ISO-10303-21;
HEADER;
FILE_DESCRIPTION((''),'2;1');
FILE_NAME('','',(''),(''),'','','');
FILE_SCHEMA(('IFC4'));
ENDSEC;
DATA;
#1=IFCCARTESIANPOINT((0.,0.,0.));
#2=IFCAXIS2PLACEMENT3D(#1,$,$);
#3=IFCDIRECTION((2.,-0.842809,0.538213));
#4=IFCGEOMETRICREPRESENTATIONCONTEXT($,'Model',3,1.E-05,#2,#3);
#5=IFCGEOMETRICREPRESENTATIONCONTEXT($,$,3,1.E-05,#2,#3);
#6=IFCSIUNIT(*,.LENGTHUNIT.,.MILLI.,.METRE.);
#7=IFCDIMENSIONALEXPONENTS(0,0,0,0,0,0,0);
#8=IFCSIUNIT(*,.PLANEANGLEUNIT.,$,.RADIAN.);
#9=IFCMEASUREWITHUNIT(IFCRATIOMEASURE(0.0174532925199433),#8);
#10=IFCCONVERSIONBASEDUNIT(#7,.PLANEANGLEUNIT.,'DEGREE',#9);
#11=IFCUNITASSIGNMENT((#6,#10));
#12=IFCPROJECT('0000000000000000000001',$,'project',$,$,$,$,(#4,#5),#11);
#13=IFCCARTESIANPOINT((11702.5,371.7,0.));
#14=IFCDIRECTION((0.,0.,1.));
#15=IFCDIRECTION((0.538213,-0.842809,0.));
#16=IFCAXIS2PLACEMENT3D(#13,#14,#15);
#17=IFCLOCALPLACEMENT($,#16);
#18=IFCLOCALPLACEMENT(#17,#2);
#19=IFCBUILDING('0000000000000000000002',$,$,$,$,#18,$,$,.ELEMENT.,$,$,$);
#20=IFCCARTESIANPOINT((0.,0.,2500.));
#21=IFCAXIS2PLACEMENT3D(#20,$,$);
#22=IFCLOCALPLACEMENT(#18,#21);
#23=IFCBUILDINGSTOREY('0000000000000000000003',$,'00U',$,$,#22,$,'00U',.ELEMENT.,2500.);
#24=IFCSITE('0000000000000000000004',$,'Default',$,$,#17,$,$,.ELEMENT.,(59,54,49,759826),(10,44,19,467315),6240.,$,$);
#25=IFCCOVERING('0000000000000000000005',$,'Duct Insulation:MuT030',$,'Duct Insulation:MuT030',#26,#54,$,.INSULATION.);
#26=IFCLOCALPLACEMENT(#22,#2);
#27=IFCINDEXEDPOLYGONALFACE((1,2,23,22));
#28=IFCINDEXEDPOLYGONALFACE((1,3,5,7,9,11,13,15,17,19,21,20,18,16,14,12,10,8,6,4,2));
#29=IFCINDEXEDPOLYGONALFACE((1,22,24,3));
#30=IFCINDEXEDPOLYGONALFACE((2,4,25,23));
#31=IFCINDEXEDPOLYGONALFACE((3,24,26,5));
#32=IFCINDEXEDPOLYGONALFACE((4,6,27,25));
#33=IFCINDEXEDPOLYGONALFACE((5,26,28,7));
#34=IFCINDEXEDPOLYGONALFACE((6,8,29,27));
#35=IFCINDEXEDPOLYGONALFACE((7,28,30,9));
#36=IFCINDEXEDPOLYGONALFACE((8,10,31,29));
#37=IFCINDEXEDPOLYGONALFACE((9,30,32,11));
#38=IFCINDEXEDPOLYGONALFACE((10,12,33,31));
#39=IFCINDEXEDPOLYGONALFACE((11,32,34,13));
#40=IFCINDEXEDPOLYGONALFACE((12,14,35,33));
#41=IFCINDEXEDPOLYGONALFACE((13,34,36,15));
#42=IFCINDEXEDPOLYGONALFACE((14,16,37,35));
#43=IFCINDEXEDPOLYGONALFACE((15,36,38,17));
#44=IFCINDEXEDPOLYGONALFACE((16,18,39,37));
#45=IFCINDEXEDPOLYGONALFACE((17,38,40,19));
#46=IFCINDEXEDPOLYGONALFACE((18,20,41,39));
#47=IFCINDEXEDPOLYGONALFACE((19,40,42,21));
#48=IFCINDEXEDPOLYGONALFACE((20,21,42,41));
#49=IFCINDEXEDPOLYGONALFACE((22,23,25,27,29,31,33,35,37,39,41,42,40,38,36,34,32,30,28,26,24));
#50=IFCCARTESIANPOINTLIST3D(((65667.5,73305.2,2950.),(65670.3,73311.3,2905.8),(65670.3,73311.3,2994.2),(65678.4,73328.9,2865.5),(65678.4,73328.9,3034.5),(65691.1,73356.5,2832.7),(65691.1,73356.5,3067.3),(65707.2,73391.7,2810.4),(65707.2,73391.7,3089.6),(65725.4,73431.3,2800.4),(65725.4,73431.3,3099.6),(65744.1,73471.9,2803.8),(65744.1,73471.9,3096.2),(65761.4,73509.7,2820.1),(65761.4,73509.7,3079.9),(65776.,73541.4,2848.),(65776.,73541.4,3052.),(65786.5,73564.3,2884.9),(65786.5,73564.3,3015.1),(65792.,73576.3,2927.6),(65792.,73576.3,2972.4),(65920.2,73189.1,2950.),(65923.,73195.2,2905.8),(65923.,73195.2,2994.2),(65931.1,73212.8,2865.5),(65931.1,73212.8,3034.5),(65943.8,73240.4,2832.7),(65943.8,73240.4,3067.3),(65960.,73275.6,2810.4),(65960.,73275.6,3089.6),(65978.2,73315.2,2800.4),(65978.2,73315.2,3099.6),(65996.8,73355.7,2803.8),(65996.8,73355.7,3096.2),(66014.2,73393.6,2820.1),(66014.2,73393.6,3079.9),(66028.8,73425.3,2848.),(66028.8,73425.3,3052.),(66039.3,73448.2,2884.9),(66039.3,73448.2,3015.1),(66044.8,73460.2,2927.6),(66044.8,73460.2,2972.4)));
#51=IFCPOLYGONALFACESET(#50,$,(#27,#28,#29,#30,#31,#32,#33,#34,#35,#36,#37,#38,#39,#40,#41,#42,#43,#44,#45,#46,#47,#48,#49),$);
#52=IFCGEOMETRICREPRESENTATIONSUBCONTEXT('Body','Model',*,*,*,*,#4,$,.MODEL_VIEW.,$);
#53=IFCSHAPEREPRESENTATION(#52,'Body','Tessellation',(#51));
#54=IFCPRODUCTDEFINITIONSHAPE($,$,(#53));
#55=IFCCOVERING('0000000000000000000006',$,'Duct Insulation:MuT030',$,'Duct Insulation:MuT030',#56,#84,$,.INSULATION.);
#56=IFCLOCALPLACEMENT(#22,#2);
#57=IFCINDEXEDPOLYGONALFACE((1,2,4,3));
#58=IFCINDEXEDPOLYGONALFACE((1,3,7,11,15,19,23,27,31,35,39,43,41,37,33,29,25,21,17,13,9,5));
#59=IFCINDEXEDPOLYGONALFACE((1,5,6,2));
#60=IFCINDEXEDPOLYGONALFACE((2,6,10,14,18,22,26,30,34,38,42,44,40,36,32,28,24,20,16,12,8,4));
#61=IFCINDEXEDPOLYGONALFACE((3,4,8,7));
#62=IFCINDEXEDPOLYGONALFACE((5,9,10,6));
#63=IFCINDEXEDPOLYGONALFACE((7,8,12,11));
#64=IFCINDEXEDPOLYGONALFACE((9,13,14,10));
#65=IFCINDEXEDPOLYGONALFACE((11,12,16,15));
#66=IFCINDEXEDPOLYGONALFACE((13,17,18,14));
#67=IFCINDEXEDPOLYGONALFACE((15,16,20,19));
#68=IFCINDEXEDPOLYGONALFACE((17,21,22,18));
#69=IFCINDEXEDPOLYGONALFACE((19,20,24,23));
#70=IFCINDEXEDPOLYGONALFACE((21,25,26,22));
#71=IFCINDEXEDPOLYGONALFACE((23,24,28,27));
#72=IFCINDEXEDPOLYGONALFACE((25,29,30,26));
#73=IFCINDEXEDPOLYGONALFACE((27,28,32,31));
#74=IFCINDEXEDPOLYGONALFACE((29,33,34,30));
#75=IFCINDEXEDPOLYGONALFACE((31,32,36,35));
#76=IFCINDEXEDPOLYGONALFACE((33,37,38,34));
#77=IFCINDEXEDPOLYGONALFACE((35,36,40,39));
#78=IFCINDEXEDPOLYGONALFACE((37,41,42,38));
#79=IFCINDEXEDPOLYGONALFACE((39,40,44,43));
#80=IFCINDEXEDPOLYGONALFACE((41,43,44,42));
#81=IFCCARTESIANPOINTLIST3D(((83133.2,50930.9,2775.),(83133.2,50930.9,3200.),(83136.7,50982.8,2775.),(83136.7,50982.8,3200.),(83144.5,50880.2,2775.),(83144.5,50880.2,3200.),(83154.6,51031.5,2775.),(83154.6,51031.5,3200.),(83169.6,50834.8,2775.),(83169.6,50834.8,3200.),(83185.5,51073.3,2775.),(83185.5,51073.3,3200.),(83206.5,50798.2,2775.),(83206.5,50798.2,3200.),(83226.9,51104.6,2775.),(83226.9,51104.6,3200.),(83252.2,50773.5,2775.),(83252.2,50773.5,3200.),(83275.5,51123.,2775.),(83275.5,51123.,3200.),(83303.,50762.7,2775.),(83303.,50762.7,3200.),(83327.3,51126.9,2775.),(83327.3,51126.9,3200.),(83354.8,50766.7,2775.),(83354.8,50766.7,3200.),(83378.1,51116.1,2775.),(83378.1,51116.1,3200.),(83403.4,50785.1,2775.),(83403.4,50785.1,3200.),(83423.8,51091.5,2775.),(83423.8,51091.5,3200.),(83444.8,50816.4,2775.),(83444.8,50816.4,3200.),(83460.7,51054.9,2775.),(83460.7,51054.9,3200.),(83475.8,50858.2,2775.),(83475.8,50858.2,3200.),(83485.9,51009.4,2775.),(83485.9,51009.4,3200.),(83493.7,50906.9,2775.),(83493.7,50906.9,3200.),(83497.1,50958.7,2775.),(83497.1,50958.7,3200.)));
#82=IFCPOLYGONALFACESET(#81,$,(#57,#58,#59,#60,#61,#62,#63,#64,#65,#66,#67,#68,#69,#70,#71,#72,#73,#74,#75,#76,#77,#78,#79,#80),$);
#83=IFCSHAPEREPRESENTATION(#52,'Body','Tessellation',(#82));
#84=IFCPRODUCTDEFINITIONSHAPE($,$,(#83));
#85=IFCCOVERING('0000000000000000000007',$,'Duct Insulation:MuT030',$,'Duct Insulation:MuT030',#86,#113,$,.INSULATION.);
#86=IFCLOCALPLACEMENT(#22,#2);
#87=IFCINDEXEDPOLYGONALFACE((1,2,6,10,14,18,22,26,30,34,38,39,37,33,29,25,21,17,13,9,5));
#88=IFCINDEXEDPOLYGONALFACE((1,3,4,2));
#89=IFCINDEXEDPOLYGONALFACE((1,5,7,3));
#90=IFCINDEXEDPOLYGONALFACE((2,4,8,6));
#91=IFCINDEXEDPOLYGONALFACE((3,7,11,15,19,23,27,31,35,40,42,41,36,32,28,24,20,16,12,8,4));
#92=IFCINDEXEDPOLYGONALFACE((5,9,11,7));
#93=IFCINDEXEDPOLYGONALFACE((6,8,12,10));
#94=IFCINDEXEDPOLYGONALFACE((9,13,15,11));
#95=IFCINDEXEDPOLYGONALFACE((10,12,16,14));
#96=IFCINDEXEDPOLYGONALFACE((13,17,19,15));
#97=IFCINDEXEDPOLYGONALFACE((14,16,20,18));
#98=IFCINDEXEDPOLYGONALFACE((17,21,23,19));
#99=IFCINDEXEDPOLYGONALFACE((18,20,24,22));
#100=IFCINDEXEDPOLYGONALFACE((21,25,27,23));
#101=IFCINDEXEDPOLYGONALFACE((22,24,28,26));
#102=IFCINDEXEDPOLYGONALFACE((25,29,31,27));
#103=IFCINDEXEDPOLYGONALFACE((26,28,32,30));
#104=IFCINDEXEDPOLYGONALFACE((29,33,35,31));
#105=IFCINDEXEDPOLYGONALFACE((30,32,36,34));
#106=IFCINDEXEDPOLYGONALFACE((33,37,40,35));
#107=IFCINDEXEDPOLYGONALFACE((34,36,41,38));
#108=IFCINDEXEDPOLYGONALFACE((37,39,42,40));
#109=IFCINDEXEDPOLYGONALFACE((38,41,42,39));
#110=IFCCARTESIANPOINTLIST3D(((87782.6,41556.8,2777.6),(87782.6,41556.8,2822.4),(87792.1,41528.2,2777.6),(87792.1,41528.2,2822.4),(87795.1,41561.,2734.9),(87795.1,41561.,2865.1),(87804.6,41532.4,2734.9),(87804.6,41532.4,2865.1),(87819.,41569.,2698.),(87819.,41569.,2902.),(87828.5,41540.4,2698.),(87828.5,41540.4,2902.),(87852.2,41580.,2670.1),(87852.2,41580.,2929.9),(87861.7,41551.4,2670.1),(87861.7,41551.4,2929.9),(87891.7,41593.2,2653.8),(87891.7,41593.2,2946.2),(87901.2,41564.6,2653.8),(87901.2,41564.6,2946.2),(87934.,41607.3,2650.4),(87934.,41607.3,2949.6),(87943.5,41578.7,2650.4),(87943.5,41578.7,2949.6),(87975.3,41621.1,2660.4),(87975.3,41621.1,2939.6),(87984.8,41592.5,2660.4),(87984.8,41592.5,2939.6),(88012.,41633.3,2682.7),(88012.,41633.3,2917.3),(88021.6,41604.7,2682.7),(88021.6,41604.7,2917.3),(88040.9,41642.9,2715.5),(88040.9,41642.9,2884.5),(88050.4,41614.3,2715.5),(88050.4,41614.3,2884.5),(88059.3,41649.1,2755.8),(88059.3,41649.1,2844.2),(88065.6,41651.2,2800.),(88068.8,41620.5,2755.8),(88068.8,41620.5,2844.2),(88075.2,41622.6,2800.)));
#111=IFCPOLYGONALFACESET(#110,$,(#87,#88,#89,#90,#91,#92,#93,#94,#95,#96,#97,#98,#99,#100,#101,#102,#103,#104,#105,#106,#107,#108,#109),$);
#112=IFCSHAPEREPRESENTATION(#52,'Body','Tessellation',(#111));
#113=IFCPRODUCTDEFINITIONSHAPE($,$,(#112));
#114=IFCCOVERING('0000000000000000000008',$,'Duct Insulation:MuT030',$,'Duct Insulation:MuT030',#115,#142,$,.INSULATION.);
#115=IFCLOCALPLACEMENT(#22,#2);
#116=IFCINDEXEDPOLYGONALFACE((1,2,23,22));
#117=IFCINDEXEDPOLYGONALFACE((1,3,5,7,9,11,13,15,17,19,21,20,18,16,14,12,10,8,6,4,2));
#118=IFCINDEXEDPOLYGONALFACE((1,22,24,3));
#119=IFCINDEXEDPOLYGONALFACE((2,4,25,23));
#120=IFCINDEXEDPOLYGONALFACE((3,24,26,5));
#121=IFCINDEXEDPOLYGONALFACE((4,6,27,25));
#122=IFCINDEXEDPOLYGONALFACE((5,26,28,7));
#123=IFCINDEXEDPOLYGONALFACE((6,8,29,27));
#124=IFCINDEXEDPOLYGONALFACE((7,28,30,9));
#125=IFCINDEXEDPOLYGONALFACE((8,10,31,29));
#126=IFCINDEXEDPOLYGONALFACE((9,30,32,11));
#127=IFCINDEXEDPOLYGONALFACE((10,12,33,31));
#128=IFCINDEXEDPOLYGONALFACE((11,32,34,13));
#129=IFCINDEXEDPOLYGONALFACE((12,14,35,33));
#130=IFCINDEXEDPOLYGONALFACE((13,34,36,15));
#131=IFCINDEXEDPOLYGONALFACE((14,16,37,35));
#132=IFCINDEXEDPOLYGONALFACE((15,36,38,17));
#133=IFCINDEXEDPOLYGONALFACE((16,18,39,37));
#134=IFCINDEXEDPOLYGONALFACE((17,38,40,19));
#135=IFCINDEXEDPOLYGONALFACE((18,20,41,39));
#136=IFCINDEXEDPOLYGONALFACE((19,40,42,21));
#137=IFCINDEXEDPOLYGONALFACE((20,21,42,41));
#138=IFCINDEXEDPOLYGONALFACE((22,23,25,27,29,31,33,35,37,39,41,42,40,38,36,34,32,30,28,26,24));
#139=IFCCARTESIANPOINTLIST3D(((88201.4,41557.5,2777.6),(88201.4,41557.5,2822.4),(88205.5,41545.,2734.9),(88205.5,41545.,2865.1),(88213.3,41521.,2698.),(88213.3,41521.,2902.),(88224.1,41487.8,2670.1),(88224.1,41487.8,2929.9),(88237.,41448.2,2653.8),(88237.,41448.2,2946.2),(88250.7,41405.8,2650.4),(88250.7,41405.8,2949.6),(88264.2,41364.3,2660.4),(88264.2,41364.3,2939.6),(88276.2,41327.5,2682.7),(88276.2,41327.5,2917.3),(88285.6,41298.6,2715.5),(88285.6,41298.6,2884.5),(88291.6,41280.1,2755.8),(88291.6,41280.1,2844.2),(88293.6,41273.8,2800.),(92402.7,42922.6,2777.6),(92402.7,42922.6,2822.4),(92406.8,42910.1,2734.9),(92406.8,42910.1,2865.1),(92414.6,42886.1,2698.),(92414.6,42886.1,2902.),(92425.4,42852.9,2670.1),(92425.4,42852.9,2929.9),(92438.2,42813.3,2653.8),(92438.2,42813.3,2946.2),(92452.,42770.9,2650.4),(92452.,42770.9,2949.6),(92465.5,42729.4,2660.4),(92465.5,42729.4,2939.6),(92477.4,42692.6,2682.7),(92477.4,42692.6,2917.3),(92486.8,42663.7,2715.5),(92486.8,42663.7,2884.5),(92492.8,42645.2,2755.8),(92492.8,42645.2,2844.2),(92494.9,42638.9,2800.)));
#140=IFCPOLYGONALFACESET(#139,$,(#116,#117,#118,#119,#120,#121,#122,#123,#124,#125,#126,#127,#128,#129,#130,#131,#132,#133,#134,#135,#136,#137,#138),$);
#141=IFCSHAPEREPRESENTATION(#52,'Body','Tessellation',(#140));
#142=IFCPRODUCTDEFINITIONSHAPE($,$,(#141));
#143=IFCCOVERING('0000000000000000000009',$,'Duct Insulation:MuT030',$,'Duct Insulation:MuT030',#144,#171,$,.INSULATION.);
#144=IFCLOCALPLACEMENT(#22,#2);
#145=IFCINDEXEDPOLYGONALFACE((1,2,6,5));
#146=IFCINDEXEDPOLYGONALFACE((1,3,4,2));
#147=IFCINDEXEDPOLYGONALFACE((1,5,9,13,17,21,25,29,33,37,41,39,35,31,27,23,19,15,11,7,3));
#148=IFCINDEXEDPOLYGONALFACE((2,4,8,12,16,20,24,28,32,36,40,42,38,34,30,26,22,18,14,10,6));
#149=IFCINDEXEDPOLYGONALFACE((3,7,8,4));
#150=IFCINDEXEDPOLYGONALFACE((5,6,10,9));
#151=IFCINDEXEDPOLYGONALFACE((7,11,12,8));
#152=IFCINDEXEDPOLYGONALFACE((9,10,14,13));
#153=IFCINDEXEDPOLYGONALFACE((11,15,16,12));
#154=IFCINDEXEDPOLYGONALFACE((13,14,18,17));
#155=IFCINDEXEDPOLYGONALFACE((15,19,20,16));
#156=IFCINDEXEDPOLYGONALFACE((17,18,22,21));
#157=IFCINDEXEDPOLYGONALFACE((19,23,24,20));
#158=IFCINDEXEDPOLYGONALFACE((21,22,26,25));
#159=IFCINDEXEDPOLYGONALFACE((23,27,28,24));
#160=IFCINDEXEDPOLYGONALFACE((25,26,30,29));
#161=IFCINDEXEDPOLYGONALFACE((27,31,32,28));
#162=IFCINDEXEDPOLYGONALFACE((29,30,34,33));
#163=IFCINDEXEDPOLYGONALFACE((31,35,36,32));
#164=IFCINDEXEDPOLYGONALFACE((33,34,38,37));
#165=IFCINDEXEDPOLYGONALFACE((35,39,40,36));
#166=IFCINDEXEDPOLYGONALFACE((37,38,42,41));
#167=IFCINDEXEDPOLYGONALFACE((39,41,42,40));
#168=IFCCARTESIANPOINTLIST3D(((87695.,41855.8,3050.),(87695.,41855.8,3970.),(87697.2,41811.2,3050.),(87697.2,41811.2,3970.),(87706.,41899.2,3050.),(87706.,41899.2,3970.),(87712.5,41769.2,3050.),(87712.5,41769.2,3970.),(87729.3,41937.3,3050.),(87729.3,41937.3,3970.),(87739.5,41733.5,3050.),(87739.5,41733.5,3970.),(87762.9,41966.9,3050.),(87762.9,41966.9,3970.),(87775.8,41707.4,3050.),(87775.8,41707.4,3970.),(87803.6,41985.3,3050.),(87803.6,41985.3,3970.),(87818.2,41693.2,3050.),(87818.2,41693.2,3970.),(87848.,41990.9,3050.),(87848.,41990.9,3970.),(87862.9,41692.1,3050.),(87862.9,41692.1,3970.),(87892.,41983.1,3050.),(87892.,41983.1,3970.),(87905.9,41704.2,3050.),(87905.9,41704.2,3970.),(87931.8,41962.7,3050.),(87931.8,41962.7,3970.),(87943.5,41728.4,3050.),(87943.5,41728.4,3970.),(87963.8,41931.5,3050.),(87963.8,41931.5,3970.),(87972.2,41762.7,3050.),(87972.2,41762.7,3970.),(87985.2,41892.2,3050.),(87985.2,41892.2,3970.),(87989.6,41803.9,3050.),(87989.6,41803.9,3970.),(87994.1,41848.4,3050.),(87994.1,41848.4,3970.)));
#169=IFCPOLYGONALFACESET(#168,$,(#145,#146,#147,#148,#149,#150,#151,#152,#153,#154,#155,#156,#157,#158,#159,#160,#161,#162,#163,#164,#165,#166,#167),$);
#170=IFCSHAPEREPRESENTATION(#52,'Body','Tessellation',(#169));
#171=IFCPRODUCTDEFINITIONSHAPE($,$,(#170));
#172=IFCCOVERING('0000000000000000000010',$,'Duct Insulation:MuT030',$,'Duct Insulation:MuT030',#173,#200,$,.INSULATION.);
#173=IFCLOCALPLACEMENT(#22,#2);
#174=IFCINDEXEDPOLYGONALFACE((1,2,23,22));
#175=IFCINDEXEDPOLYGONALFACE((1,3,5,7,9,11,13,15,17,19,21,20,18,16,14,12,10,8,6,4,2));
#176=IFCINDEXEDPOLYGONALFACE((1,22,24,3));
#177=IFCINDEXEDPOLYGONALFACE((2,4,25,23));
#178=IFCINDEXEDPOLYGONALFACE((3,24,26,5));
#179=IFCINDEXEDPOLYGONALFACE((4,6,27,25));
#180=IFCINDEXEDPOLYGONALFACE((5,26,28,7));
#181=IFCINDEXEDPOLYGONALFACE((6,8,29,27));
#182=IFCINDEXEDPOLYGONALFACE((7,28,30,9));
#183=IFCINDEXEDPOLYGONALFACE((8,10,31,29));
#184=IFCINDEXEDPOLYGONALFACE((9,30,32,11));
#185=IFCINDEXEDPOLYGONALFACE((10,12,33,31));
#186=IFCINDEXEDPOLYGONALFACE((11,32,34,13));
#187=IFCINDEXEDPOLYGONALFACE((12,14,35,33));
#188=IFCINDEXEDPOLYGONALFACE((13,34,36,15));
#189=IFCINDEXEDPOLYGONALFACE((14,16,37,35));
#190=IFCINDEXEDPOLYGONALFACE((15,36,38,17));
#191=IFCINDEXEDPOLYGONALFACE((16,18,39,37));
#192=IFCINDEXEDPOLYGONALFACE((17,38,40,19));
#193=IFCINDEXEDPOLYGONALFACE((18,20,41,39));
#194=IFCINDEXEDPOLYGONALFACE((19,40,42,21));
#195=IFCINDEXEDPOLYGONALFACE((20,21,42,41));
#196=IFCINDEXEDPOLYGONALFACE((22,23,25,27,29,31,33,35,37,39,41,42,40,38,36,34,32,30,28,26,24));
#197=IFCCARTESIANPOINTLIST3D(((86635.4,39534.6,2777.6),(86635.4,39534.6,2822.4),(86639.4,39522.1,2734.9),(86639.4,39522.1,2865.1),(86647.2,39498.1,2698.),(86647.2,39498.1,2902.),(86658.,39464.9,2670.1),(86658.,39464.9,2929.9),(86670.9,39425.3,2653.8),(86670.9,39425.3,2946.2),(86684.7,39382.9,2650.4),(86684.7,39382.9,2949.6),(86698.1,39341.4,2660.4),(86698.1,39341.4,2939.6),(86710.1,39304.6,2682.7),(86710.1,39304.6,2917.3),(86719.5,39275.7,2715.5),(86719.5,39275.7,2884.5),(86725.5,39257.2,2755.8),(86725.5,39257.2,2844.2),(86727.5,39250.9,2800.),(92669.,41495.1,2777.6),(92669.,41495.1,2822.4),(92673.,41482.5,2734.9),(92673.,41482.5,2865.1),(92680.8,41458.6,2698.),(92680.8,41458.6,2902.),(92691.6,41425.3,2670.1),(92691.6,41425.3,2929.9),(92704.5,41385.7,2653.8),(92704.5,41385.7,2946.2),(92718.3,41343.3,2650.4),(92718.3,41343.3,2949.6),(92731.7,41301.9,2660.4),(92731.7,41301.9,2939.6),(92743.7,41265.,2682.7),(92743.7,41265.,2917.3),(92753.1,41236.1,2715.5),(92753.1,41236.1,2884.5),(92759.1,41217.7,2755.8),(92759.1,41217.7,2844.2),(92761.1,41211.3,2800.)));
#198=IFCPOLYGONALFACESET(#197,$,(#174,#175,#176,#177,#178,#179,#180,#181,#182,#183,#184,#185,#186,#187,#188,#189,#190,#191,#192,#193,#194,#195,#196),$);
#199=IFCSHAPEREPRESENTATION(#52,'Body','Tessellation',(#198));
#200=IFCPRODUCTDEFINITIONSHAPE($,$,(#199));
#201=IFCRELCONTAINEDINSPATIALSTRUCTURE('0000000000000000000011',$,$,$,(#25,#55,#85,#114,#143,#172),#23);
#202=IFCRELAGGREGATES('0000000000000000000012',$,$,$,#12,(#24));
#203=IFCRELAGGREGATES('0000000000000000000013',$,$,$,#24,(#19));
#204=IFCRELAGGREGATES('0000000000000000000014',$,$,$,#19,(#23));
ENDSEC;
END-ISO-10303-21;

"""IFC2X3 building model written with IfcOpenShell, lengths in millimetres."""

from ifc_helpers import new_model, entity, si_unit, converted_unit, direction, frame, frame_2d, origin, origin_2d_with_axis, place, context, subcontext, project, spatial, circle, extrude, element, save


model = new_model("IFC2X3")

# Units and contexts
model_context = context("Model", 3, precision=1e-05, world=origin(), true_north=direction((2.0, -0.842809, 0.538213)))
context_of_model = context(None, 3, precision=1e-05, world=origin(), true_north=direction((2.0, -0.842809, 0.538213)))
body_context = subcontext(model_context, "Body", "Model", "MODEL_VIEW")
ifc_project = project(units=[si_unit("LENGTHUNIT", "METRE", prefix="MILLI"), converted_unit("PLANEANGLEUNIT", "DEGREE", entity("IfcRatioMeasure", 0.0174532925199433), si_unit("PLANEANGLEUNIT", "RADIAN"), dimensions=[0, 0, 0, 0, 0, 0, 0])], contexts=[model_context, context_of_model])

# Site, building, storey
site_placement = place(None, frame((11702.5, 371.7, 0.0), z_axis=(0.0, 0.0, 1.0), x_axis=(0.538213, -0.842809, 0.0)))
site = spatial("IfcSite", under=ifc_project, at=site_placement, Name="Default", CompositionType="ELEMENT", RefLatitude=(59, 54, 49, 759826), RefLongitude=(10, 44, 19, 467315), RefElevation=6240.0)
building_placement = place(site_placement, origin())
building = spatial("IfcBuilding", under=site, at=building_placement, CompositionType="ELEMENT")
storey_placement = place(building_placement, frame((0.0, 0.0, 2500.0)))
storey = spatial("IfcBuildingStorey", under=building, at=storey_placement, Name="00U", LongName="00U", CompositionType="ELEMENT", Elevation=2500.0)

# Coverings
covering_1_placement = place(storey_placement, origin())
element("IfcCovering", 1, at=covering_1_placement, inside=storey, Name="Duct Insulation:MuT030", ObjectType="Duct Insulation:MuT030", PredefinedType="INSULATION", context=body_context, shape_type="SweptSolid", body=[
    extrude(circle(Radius=150.0, at=origin_2d_with_axis()), frame((65730.1, 73441.5, 2950.0), z_axis=(0.90867, -0.417515, 0.0), x_axis=(-0.417515, -0.90867, 0.0)), (0.0, 0.0, 1.0), 278.1),
])
covering_2_placement = place(storey_placement, origin())
element("IfcCovering", 2, at=covering_2_placement, inside=storey, Name="Duct Insulation:MuT030", ObjectType="Duct Insulation:MuT030", PredefinedType="INSULATION", context=body_context, shape_type="SweptSolid", body=[
    extrude(circle(Radius=182.5, at=frame_2d((0.0, 0.0), x_axis=(1.0, 0.0))), frame((83315.2, 50944.8, 2775.0), z_axis=(0.0, 0.0, 1.0), x_axis=(0.710543, -0.703653, 0.0)), (0.0, 0.0, 1.0), 425.0),
])
covering_3_placement = place(storey_placement, origin())
element("IfcCovering", 3, at=covering_3_placement, inside=storey, Name="Duct Insulation:MuT030", ObjectType="Duct Insulation:MuT030", PredefinedType="INSULATION", context=body_context, shape_type="SweptSolid", body=[
    extrude(circle(Radius=150.0, at=origin_2d_with_axis()), frame((87932.9, 41575.1, 2800.0), z_axis=(-0.316277, 0.948667, 0.0), x_axis=(0.948667, 0.316277, 0.0)), (0.0, 0.0, 1.0), 30.1),
])
covering_4_placement = place(storey_placement, origin())
element("IfcCovering", 4, at=covering_4_placement, inside=storey, Name="Duct Insulation:MuT030", ObjectType="Duct Insulation:MuT030", PredefinedType="INSULATION", context=body_context, shape_type="SweptSolid", body=[
    extrude(circle(Radius=150.0, at=origin_2d_with_axis()), frame((88247.3, 41416.4, 2800.0), z_axis=(0.951057, 0.309017, 0.0), x_axis=(0.309017, -0.951057, 0.0)), (0.0, 0.0, 1.0), 4417.5),
])
covering_5_placement = place(storey_placement, origin())
element("IfcCovering", 5, at=covering_5_placement, inside=storey, Name="Duct Insulation:MuT030", ObjectType="Duct Insulation:MuT030", PredefinedType="INSULATION", context=body_context, shape_type="SweptSolid", body=[
    extrude(circle(Radius=150.0, at=frame_2d((0.0, 0.0), x_axis=(1.0, 0.0))), frame((87844.2, 41840.9, 3050.0), z_axis=(0.000001, 0.0, 1.0), x_axis=(0.939693, 0.34202, -0.000001)), (0.0, 0.0, 1.0), 920.0),
])
covering_6_placement = place(storey_placement, origin())
element("IfcCovering", 6, at=covering_6_placement, inside=storey, Name="Duct Insulation:MuT030", ObjectType="Duct Insulation:MuT030", PredefinedType="INSULATION", context=body_context, shape_type="SweptSolid", body=[
    extrude(circle(Radius=150.0, at=origin_2d_with_axis()), frame((86681.2, 39393.6, 2800.0), z_axis=(0.951057, 0.309017, 0.0), x_axis=(0.309017, -0.951057, 0.0)), (0.0, 0.0, 1.0), 6344.1),
])

save(model, "model.ifc")
